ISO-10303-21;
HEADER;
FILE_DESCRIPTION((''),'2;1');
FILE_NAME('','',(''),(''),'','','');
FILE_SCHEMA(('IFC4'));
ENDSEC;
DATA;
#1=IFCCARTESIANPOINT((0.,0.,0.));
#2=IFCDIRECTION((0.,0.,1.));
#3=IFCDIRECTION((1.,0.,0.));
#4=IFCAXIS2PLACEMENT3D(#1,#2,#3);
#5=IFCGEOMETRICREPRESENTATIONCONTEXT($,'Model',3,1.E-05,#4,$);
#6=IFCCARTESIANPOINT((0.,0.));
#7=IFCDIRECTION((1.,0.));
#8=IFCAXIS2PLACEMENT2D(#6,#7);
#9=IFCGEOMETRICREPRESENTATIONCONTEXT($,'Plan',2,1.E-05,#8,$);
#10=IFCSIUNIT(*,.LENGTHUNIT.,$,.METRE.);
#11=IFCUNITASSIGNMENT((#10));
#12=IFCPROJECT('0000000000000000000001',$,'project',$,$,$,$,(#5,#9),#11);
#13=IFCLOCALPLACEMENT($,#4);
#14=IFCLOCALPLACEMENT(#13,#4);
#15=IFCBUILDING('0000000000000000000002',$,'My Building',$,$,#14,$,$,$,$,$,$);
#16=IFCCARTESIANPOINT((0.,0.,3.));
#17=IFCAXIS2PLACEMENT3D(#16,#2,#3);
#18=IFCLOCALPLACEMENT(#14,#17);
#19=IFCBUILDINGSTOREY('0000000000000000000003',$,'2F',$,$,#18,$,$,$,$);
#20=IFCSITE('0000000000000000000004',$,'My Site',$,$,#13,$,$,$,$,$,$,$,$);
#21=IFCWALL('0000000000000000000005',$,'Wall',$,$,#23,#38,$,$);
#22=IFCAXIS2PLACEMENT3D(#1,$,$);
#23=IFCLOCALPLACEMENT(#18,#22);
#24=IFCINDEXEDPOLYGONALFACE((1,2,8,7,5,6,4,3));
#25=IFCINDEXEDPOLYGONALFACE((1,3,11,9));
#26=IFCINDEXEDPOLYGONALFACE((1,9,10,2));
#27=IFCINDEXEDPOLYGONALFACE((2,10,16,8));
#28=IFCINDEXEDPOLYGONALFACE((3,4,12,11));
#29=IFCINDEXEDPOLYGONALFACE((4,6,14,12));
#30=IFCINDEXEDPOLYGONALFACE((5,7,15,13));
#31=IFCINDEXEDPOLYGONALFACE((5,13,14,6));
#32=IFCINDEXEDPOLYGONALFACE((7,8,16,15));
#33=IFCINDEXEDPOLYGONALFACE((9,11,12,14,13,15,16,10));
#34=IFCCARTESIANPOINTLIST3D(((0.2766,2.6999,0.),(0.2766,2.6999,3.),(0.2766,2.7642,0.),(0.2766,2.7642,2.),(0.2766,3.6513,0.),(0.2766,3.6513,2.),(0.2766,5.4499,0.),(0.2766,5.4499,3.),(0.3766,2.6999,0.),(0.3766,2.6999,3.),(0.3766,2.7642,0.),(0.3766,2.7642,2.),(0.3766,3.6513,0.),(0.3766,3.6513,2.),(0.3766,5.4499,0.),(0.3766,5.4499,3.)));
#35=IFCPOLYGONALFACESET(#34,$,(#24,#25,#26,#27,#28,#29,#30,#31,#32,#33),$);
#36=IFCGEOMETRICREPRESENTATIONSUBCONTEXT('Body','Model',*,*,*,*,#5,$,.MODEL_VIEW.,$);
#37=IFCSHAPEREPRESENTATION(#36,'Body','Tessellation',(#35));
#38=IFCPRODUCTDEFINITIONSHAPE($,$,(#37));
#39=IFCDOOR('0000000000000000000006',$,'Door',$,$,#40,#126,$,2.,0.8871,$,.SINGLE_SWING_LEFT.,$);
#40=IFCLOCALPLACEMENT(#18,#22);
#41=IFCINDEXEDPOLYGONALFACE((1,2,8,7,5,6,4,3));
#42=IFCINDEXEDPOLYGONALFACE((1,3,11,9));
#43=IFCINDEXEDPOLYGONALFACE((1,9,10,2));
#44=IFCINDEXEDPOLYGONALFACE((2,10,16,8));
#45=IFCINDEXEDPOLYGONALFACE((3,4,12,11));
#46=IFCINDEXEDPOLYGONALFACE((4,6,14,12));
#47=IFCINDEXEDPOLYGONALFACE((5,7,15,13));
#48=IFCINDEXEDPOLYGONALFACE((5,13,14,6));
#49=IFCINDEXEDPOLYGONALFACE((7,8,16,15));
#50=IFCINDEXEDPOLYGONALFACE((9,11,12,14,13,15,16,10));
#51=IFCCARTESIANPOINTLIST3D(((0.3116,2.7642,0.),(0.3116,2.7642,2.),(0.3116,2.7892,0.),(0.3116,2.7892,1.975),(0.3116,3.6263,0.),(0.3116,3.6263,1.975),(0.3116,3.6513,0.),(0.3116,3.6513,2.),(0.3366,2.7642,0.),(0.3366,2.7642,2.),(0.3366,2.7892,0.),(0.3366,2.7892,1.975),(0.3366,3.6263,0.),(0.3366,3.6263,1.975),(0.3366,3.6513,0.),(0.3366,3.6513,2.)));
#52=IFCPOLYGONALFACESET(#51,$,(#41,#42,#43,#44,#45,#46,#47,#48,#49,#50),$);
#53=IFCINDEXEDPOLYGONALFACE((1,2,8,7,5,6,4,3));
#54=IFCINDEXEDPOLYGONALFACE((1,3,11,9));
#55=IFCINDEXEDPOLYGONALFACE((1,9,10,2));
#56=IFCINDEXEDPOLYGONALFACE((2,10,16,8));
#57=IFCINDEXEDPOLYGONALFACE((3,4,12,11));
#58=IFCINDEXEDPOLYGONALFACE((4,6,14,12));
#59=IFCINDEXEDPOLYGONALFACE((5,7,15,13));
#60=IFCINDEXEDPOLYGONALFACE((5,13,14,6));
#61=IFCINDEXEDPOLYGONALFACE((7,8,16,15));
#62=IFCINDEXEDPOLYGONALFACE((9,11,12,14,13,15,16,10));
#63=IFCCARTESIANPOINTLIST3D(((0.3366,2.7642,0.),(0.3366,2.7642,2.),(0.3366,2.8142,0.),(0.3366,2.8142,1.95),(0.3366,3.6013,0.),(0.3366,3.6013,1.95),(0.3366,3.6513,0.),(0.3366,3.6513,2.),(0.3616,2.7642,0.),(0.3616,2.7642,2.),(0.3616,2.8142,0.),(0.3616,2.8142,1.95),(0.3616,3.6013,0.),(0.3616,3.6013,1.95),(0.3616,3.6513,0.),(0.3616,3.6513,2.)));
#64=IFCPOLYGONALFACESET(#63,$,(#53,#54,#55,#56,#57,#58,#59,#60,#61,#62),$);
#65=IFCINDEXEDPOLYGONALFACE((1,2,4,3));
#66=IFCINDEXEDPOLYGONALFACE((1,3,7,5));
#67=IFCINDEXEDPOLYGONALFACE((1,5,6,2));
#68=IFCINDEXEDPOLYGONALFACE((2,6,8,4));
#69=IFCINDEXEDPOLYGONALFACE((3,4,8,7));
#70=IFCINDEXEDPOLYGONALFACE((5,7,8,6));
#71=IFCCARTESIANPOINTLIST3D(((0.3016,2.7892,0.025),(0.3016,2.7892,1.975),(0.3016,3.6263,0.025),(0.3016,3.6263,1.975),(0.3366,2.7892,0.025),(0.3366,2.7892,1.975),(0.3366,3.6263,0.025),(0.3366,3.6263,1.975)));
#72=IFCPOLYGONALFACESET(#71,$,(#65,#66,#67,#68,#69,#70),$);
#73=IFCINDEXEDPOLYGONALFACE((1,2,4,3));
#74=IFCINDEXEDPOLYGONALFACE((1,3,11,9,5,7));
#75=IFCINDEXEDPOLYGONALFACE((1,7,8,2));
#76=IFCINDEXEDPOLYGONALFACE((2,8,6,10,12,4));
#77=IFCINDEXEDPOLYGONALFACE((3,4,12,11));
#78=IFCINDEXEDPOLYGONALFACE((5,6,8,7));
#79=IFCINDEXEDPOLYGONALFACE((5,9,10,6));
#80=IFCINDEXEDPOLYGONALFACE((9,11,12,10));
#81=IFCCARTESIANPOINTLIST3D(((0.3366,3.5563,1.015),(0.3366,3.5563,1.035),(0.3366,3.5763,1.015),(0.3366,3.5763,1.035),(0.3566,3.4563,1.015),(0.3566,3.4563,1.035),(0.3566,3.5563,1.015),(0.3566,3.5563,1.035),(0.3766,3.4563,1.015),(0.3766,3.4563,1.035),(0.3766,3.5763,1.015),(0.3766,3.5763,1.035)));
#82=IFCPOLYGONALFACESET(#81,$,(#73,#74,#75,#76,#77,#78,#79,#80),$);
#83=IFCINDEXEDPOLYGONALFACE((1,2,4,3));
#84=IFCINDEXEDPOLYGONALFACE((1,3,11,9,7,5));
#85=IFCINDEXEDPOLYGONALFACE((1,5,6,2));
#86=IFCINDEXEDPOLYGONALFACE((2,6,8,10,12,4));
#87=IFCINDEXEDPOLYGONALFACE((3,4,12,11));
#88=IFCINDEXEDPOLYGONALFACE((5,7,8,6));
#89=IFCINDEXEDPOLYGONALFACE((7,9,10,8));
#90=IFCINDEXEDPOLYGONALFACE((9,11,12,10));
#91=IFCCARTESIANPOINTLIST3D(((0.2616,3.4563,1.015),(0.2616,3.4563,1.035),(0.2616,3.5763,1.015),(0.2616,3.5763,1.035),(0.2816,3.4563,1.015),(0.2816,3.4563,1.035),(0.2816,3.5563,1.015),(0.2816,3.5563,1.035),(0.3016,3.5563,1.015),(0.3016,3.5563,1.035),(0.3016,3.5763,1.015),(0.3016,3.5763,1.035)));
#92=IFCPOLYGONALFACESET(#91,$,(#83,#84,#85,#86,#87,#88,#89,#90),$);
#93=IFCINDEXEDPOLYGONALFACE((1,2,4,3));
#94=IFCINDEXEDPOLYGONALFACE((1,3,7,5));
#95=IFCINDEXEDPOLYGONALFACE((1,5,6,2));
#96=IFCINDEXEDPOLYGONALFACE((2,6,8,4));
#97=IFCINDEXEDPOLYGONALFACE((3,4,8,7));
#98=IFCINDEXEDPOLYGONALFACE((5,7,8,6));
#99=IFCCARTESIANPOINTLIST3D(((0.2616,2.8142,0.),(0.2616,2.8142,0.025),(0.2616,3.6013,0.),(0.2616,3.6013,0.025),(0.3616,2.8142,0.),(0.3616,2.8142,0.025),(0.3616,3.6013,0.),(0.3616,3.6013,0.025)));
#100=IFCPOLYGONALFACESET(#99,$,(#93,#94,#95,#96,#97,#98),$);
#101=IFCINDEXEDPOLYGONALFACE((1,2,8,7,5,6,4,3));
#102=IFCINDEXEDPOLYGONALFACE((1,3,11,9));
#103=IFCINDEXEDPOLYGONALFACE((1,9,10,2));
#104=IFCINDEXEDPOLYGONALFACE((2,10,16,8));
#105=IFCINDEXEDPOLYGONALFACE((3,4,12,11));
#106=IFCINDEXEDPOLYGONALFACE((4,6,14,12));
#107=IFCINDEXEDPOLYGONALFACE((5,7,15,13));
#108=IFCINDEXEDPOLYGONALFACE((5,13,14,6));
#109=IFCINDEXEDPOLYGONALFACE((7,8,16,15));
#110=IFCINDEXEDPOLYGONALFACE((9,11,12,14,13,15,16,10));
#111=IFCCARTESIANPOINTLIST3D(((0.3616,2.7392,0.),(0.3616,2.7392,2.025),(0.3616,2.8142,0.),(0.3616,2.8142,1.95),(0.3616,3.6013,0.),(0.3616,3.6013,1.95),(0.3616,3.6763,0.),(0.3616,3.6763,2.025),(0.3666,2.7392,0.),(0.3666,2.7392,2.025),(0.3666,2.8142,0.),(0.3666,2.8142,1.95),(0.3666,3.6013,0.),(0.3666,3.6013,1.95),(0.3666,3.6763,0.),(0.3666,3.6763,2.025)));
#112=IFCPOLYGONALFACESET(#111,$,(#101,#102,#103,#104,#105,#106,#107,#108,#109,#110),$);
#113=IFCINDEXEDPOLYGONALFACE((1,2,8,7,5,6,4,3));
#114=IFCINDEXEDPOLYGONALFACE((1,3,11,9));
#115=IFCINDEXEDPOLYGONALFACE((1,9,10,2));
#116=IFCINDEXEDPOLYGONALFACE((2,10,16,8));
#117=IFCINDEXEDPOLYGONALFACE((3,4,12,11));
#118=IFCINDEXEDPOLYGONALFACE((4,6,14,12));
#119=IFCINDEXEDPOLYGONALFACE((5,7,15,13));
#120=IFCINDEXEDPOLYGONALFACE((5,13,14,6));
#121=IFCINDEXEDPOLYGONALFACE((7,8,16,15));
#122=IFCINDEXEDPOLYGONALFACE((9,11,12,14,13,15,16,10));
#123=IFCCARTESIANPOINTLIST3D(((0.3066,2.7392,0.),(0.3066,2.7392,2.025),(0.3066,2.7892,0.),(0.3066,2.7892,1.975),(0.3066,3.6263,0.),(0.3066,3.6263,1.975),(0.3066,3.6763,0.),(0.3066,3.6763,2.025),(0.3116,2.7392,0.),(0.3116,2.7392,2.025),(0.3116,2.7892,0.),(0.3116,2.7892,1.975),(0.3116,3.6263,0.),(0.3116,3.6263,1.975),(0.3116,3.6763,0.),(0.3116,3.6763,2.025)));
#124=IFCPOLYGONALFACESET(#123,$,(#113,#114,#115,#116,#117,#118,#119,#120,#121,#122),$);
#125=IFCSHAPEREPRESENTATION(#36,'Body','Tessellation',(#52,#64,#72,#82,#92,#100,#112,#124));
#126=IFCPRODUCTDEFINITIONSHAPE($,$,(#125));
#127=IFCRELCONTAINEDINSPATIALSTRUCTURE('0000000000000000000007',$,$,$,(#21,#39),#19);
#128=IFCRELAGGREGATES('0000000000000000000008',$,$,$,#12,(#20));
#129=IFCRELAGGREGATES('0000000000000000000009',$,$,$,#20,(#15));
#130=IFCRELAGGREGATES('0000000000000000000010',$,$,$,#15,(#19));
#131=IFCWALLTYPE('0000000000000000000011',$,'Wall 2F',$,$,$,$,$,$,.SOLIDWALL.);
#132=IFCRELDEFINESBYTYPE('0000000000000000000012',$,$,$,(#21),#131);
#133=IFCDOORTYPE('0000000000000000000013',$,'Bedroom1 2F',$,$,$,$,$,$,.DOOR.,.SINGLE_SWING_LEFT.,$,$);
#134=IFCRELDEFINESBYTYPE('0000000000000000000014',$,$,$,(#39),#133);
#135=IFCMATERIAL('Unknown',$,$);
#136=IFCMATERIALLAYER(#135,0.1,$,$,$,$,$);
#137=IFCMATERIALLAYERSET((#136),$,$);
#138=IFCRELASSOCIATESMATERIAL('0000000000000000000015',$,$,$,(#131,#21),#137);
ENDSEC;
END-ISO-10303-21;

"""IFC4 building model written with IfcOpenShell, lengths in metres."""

from ifc_helpers import new_model, entity, si_unit, frame, origin_with_axes, origin_2d_with_axis, place, context, subcontext, project, spatial, line, indexed_curve, outline, extrude, shape, source, transform, mapped, material, layer, layer_set, layer_usage, type_object, type_shapes, element, fill, save


model = new_model("IFC4")

# Units and contexts
model_context = context("Model", 3, precision=1e-05, world=origin_with_axes())
plan_context = context("Plan", 2, precision=1e-05, world=origin_2d_with_axis())
body_context_1 = subcontext(model_context, "Body", "Model", "MODEL_VIEW")
body_context_2 = subcontext(plan_context, "Body", "Plan", "PLAN_VIEW")
ifc_project = project(units=[si_unit("LENGTHUNIT", "METRE")], contexts=[model_context, plan_context])

# Site, building, storey
site_placement = place(None, origin_with_axes())
site = spatial("IfcSite", under=ifc_project, at=site_placement, Name="My Site")
building_placement = place(site_placement, origin_with_axes())
building = spatial("IfcBuilding", under=site, at=building_placement, Name="My Building")
storey_placement = place(building_placement, frame((0.0, 0.0, 3.0), z_axis=(0.0, 0.0, 1.0), x_axis=(1.0, 0.0, 0.0)))
storey = spatial("IfcBuildingStorey", under=building, at=storey_placement, Name="2F")

# Shared definitions
ifc_material = material(Name="Unknown")

# Shared definitions
ifc_layer_1 = layer(ifc_material, 0.1)
ifc_layer_set_1 = layer_set([ifc_layer_1])
wall_type = type_object("IfcWallType", Name="Wall 2F", PredefinedType="SOLIDWALL", material=ifc_layer_set_1)

# Wall, opening, door
ifc_layer_usage_1 = layer_usage(ifc_layer_set_1, "AXIS2", "POSITIVE", 0.0)
wall_1_placement = place(storey_placement, frame((0.3766, 2.6999, 0.0), z_axis=(0.0, 0.0, 1.0), x_axis=(0.0, 1.0, 0.0)))
wall_1 = element("IfcWall", 1, at=wall_1_placement, inside=storey, type_object=wall_type, material=ifc_layer_usage_1, Name="Wall", context=body_context_1, shape_type="SweptSolid", body=[
    extrude(outline(indexed_curve([(0.0, 0.0), (0.0, 0.1), (2.75, 0.1), (2.75, 0.0)], segments=[line(1, 2, 3, 4, 1)])), origin_with_axes(), (0.0, 0.0, 1.0), 3.0),
])
shared_shape_1 = source(origin_with_axes(), body_context_1, "Body", "SweptSolid", [
    extrude(outline(indexed_curve([(0.0, 0.0), (0.8871, 0.0), (0.8871, 2.0), (0.0, 2.0)], segments=[line(1, 2, 3, 4, 1)])), frame((0.0, -0.6, 0.0), z_axis=(0.0, -1.0, 0.0), x_axis=(1.0, 0.0, 0.0)), (0.0, 0.0, -1.0), 1.2),
])
opening_1_placement = place(wall_1_placement, frame((0.0644, 0.015, 0.0), z_axis=(0.0, 0.0, 1.0), x_axis=(1.0, 0.0, 0.0)))
opening_1 = element("IfcOpeningElement", 2, at=opening_1_placement, cuts=wall_1, PredefinedType="OPENING", context=body_context_1, shape_type="MappedRepresentation", body=[
    mapped(shared_shape_1, transform((0.0, 0.0, 0.0), x_axis=(1.0, 0.0, 0.0), y_axis=(0.0, 1.0, 0.0), z_axis=(0.0, 0.0, 1.0), scale=1.0)),
])
door_type_1 = type_object("IfcDoorType", Name="Bedroom1 2F", OperationType="SINGLE_SWING_LEFT", PredefinedType="DOOR")
shared_shape_2 = source(origin_with_axes(), body_context_1, "Body", "SweptSolid", [
    extrude(outline(indexed_curve([(0.0, 0.0), (0.0, 2.0), (0.8871, 2.0), (0.8871, 0.0), (0.8621, 0.0), (0.8621, 1.975), (0.025, 1.975), (0.025, 0.0)], segments=[line(1, 2, 3, 4, 5, 6, 7, 8, 1)])), frame((0.0, 0.025, 0.0), z_axis=(0.0, -1.0, 0.0), x_axis=(1.0, 0.0, 0.0)), (0.0, 0.0, -1.0), 0.025),
    extrude(outline(indexed_curve([(0.0, 0.0), (0.0, 2.0), (0.8871, 2.0), (0.8871, 0.0), (0.8371, 0.0), (0.8371, 1.95), (0.05, 1.95), (0.05, 0.0)], segments=[line(1, 2, 3, 4, 5, 6, 7, 8, 1)])), frame((0.0, 0.0, 0.0), z_axis=(0.0, -1.0, 0.0), x_axis=(1.0, 0.0, 0.0)), (0.0, 0.0, -1.0), 0.025),
    extrude(outline(indexed_curve([(0.0, 0.0), (0.8371, 0.0), (0.8371, 0.035), (0.0, 0.035)], segments=[line(1, 2, 3, 4, 1)])), frame((0.025, 0.025, 0.025), z_axis=(0.0, 0.0, 1.0), x_axis=(1.0, 0.0, 0.0)), (0.0, 0.0, 1.0), 1.95),
    extrude(outline(indexed_curve([(0.0, 0.0), (0.0, -0.04), (-0.12, -0.04), (-0.12, -0.02), (-0.02, -0.02), (-0.02, 0.0)], segments=[line(1, 2, 3, 4, 5, 6, 1)])), frame((0.8121, 0.025, 1.015), z_axis=(0.0, 0.0, 1.0), x_axis=(1.0, 0.0, 0.0)), (0.0, 0.0, 1.0), 0.02),
    extrude(outline(indexed_curve([(0.0, 0.0), (0.0, 0.04), (-0.12, 0.04), (-0.12, 0.02), (-0.02, 0.02), (-0.02, 0.0)], segments=[line(1, 2, 3, 4, 5, 6, 1)])), frame((0.8121, 0.06, 1.015), z_axis=(0.0, 0.0, 1.0), x_axis=(1.0, 0.0, 0.0)), (0.0, 0.0, 1.0), 0.02),
    extrude(outline(indexed_curve([(0.0, 0.0), (0.7871, 0.0), (0.7871, 0.1), (0.0, 0.1)], segments=[line(1, 2, 3, 4, 1)])), frame((0.05, 0.0, 0.0), z_axis=(0.0, 0.0, 1.0), x_axis=(1.0, 0.0, 0.0)), (0.0, 0.0, 1.0), 0.025),
    extrude(outline(indexed_curve([(0.0, 0.0), (0.0, 2.025), (0.9371, 2.025), (0.9371, 0.0), (0.8621, 0.0), (0.8621, 1.95), (0.075, 1.95), (0.075, 0.0)], segments=[line(1, 2, 3, 4, 5, 6, 7, 8, 1)])), frame((-0.025, -0.005, 0.0), z_axis=(0.0, -1.0, 0.0), x_axis=(1.0, 0.0, 0.0)), (0.0, 0.0, -1.0), 0.005),
    extrude(outline(indexed_curve([(0.0, 0.0), (0.0, 2.025), (0.9371, 2.025), (0.9371, 0.0), (0.8871, 0.0), (0.8871, 1.975), (0.05, 1.975), (0.05, 0.0)], segments=[line(1, 2, 3, 4, 5, 6, 7, 8, 1)])), frame((-0.025, 0.05, 0.0), z_axis=(0.0, -1.0, 0.0), x_axis=(1.0, 0.0, 0.0)), (0.0, 0.0, -1.0), 0.005),
])
shared_shape_3 = source(origin_with_axes(), body_context_2, "Body", "Curve2D", [
    entity("IfcIndexedPolyCurve", entity("IfcCartesianPointList2D", [[0.0, 0.0], [0.0, 0.05], [0.025, 0.05], [0.025, 0.025], [0.05, 0.025], [0.05, 0.0]]), [entity("IfcLineIndex", [1, 2, 3, 4, 5, 6, 1])]),
    entity("IfcIndexedPolyCurve", entity("IfcCartesianPointList2D", [[0.8871, 0.0], [0.8871, 0.05], [0.8621, 0.05], [0.8621, 0.025], [0.8371, 0.025], [0.8371, 0.0]]), [entity("IfcLineIndex", [1, 2, 3, 4, 5, 6, 1])]),
    entity("IfcTrimmedCurve", entity("IfcEllipse", entity("IfcAxis2Placement2D", entity("IfcCartesianPoint", [0.06, 0.05]), entity("IfcDirection", [1.0, 0.0])), 0.8021, 0.8371), [entity("IfcCartesianPoint", [0.8621, 0.05])], [entity("IfcCartesianPoint", [0.06, 0.8871])], True, "CARTESIAN"),
    entity("IfcIndexedPolyCurve", entity("IfcCartesianPointList2D", [[0.025, 0.05], [0.06, 0.05], [0.06, 0.8871], [0.025, 0.8871]]), [entity("IfcLineIndex", [1, 2, 3, 4, 1])]),
])
type_shapes(door_type_1, [shared_shape_2, shared_shape_3])
door_1_placement = place(opening_1_placement, frame((0.0, 0.0, 0.0), z_axis=(0.0, 0.0, 1.0), x_axis=(1.0, 0.0, 0.0)))
door_1 = element("IfcDoor", 3, at=door_1_placement, inside=storey, type_object=door_type_1, Name="Door", OperationType="SINGLE_SWING_LEFT", OverallHeight=2.0, OverallWidth=0.8871, shapes=[
    shape(body_context_1, "Body", "MappedRepresentation", [mapped(shared_shape_2, transform((0.0, 0.0, 0.0), x_axis=(1.0, 0.0, 0.0), y_axis=(0.0, 1.0, 0.0), z_axis=(0.0, 0.0, 1.0), scale=1.0))]),
    shape(body_context_2, "Body", "MappedRepresentation", [mapped(shared_shape_3, transform((0.0, 0.0, 0.0), x_axis=(1.0, 0.0, 0.0), y_axis=(0.0, 1.0, 0.0), z_axis=(0.0, 0.0, 1.0), scale=1.0))]),
])
fill(opening_1, door_1)

save(model, "model.ifc")
